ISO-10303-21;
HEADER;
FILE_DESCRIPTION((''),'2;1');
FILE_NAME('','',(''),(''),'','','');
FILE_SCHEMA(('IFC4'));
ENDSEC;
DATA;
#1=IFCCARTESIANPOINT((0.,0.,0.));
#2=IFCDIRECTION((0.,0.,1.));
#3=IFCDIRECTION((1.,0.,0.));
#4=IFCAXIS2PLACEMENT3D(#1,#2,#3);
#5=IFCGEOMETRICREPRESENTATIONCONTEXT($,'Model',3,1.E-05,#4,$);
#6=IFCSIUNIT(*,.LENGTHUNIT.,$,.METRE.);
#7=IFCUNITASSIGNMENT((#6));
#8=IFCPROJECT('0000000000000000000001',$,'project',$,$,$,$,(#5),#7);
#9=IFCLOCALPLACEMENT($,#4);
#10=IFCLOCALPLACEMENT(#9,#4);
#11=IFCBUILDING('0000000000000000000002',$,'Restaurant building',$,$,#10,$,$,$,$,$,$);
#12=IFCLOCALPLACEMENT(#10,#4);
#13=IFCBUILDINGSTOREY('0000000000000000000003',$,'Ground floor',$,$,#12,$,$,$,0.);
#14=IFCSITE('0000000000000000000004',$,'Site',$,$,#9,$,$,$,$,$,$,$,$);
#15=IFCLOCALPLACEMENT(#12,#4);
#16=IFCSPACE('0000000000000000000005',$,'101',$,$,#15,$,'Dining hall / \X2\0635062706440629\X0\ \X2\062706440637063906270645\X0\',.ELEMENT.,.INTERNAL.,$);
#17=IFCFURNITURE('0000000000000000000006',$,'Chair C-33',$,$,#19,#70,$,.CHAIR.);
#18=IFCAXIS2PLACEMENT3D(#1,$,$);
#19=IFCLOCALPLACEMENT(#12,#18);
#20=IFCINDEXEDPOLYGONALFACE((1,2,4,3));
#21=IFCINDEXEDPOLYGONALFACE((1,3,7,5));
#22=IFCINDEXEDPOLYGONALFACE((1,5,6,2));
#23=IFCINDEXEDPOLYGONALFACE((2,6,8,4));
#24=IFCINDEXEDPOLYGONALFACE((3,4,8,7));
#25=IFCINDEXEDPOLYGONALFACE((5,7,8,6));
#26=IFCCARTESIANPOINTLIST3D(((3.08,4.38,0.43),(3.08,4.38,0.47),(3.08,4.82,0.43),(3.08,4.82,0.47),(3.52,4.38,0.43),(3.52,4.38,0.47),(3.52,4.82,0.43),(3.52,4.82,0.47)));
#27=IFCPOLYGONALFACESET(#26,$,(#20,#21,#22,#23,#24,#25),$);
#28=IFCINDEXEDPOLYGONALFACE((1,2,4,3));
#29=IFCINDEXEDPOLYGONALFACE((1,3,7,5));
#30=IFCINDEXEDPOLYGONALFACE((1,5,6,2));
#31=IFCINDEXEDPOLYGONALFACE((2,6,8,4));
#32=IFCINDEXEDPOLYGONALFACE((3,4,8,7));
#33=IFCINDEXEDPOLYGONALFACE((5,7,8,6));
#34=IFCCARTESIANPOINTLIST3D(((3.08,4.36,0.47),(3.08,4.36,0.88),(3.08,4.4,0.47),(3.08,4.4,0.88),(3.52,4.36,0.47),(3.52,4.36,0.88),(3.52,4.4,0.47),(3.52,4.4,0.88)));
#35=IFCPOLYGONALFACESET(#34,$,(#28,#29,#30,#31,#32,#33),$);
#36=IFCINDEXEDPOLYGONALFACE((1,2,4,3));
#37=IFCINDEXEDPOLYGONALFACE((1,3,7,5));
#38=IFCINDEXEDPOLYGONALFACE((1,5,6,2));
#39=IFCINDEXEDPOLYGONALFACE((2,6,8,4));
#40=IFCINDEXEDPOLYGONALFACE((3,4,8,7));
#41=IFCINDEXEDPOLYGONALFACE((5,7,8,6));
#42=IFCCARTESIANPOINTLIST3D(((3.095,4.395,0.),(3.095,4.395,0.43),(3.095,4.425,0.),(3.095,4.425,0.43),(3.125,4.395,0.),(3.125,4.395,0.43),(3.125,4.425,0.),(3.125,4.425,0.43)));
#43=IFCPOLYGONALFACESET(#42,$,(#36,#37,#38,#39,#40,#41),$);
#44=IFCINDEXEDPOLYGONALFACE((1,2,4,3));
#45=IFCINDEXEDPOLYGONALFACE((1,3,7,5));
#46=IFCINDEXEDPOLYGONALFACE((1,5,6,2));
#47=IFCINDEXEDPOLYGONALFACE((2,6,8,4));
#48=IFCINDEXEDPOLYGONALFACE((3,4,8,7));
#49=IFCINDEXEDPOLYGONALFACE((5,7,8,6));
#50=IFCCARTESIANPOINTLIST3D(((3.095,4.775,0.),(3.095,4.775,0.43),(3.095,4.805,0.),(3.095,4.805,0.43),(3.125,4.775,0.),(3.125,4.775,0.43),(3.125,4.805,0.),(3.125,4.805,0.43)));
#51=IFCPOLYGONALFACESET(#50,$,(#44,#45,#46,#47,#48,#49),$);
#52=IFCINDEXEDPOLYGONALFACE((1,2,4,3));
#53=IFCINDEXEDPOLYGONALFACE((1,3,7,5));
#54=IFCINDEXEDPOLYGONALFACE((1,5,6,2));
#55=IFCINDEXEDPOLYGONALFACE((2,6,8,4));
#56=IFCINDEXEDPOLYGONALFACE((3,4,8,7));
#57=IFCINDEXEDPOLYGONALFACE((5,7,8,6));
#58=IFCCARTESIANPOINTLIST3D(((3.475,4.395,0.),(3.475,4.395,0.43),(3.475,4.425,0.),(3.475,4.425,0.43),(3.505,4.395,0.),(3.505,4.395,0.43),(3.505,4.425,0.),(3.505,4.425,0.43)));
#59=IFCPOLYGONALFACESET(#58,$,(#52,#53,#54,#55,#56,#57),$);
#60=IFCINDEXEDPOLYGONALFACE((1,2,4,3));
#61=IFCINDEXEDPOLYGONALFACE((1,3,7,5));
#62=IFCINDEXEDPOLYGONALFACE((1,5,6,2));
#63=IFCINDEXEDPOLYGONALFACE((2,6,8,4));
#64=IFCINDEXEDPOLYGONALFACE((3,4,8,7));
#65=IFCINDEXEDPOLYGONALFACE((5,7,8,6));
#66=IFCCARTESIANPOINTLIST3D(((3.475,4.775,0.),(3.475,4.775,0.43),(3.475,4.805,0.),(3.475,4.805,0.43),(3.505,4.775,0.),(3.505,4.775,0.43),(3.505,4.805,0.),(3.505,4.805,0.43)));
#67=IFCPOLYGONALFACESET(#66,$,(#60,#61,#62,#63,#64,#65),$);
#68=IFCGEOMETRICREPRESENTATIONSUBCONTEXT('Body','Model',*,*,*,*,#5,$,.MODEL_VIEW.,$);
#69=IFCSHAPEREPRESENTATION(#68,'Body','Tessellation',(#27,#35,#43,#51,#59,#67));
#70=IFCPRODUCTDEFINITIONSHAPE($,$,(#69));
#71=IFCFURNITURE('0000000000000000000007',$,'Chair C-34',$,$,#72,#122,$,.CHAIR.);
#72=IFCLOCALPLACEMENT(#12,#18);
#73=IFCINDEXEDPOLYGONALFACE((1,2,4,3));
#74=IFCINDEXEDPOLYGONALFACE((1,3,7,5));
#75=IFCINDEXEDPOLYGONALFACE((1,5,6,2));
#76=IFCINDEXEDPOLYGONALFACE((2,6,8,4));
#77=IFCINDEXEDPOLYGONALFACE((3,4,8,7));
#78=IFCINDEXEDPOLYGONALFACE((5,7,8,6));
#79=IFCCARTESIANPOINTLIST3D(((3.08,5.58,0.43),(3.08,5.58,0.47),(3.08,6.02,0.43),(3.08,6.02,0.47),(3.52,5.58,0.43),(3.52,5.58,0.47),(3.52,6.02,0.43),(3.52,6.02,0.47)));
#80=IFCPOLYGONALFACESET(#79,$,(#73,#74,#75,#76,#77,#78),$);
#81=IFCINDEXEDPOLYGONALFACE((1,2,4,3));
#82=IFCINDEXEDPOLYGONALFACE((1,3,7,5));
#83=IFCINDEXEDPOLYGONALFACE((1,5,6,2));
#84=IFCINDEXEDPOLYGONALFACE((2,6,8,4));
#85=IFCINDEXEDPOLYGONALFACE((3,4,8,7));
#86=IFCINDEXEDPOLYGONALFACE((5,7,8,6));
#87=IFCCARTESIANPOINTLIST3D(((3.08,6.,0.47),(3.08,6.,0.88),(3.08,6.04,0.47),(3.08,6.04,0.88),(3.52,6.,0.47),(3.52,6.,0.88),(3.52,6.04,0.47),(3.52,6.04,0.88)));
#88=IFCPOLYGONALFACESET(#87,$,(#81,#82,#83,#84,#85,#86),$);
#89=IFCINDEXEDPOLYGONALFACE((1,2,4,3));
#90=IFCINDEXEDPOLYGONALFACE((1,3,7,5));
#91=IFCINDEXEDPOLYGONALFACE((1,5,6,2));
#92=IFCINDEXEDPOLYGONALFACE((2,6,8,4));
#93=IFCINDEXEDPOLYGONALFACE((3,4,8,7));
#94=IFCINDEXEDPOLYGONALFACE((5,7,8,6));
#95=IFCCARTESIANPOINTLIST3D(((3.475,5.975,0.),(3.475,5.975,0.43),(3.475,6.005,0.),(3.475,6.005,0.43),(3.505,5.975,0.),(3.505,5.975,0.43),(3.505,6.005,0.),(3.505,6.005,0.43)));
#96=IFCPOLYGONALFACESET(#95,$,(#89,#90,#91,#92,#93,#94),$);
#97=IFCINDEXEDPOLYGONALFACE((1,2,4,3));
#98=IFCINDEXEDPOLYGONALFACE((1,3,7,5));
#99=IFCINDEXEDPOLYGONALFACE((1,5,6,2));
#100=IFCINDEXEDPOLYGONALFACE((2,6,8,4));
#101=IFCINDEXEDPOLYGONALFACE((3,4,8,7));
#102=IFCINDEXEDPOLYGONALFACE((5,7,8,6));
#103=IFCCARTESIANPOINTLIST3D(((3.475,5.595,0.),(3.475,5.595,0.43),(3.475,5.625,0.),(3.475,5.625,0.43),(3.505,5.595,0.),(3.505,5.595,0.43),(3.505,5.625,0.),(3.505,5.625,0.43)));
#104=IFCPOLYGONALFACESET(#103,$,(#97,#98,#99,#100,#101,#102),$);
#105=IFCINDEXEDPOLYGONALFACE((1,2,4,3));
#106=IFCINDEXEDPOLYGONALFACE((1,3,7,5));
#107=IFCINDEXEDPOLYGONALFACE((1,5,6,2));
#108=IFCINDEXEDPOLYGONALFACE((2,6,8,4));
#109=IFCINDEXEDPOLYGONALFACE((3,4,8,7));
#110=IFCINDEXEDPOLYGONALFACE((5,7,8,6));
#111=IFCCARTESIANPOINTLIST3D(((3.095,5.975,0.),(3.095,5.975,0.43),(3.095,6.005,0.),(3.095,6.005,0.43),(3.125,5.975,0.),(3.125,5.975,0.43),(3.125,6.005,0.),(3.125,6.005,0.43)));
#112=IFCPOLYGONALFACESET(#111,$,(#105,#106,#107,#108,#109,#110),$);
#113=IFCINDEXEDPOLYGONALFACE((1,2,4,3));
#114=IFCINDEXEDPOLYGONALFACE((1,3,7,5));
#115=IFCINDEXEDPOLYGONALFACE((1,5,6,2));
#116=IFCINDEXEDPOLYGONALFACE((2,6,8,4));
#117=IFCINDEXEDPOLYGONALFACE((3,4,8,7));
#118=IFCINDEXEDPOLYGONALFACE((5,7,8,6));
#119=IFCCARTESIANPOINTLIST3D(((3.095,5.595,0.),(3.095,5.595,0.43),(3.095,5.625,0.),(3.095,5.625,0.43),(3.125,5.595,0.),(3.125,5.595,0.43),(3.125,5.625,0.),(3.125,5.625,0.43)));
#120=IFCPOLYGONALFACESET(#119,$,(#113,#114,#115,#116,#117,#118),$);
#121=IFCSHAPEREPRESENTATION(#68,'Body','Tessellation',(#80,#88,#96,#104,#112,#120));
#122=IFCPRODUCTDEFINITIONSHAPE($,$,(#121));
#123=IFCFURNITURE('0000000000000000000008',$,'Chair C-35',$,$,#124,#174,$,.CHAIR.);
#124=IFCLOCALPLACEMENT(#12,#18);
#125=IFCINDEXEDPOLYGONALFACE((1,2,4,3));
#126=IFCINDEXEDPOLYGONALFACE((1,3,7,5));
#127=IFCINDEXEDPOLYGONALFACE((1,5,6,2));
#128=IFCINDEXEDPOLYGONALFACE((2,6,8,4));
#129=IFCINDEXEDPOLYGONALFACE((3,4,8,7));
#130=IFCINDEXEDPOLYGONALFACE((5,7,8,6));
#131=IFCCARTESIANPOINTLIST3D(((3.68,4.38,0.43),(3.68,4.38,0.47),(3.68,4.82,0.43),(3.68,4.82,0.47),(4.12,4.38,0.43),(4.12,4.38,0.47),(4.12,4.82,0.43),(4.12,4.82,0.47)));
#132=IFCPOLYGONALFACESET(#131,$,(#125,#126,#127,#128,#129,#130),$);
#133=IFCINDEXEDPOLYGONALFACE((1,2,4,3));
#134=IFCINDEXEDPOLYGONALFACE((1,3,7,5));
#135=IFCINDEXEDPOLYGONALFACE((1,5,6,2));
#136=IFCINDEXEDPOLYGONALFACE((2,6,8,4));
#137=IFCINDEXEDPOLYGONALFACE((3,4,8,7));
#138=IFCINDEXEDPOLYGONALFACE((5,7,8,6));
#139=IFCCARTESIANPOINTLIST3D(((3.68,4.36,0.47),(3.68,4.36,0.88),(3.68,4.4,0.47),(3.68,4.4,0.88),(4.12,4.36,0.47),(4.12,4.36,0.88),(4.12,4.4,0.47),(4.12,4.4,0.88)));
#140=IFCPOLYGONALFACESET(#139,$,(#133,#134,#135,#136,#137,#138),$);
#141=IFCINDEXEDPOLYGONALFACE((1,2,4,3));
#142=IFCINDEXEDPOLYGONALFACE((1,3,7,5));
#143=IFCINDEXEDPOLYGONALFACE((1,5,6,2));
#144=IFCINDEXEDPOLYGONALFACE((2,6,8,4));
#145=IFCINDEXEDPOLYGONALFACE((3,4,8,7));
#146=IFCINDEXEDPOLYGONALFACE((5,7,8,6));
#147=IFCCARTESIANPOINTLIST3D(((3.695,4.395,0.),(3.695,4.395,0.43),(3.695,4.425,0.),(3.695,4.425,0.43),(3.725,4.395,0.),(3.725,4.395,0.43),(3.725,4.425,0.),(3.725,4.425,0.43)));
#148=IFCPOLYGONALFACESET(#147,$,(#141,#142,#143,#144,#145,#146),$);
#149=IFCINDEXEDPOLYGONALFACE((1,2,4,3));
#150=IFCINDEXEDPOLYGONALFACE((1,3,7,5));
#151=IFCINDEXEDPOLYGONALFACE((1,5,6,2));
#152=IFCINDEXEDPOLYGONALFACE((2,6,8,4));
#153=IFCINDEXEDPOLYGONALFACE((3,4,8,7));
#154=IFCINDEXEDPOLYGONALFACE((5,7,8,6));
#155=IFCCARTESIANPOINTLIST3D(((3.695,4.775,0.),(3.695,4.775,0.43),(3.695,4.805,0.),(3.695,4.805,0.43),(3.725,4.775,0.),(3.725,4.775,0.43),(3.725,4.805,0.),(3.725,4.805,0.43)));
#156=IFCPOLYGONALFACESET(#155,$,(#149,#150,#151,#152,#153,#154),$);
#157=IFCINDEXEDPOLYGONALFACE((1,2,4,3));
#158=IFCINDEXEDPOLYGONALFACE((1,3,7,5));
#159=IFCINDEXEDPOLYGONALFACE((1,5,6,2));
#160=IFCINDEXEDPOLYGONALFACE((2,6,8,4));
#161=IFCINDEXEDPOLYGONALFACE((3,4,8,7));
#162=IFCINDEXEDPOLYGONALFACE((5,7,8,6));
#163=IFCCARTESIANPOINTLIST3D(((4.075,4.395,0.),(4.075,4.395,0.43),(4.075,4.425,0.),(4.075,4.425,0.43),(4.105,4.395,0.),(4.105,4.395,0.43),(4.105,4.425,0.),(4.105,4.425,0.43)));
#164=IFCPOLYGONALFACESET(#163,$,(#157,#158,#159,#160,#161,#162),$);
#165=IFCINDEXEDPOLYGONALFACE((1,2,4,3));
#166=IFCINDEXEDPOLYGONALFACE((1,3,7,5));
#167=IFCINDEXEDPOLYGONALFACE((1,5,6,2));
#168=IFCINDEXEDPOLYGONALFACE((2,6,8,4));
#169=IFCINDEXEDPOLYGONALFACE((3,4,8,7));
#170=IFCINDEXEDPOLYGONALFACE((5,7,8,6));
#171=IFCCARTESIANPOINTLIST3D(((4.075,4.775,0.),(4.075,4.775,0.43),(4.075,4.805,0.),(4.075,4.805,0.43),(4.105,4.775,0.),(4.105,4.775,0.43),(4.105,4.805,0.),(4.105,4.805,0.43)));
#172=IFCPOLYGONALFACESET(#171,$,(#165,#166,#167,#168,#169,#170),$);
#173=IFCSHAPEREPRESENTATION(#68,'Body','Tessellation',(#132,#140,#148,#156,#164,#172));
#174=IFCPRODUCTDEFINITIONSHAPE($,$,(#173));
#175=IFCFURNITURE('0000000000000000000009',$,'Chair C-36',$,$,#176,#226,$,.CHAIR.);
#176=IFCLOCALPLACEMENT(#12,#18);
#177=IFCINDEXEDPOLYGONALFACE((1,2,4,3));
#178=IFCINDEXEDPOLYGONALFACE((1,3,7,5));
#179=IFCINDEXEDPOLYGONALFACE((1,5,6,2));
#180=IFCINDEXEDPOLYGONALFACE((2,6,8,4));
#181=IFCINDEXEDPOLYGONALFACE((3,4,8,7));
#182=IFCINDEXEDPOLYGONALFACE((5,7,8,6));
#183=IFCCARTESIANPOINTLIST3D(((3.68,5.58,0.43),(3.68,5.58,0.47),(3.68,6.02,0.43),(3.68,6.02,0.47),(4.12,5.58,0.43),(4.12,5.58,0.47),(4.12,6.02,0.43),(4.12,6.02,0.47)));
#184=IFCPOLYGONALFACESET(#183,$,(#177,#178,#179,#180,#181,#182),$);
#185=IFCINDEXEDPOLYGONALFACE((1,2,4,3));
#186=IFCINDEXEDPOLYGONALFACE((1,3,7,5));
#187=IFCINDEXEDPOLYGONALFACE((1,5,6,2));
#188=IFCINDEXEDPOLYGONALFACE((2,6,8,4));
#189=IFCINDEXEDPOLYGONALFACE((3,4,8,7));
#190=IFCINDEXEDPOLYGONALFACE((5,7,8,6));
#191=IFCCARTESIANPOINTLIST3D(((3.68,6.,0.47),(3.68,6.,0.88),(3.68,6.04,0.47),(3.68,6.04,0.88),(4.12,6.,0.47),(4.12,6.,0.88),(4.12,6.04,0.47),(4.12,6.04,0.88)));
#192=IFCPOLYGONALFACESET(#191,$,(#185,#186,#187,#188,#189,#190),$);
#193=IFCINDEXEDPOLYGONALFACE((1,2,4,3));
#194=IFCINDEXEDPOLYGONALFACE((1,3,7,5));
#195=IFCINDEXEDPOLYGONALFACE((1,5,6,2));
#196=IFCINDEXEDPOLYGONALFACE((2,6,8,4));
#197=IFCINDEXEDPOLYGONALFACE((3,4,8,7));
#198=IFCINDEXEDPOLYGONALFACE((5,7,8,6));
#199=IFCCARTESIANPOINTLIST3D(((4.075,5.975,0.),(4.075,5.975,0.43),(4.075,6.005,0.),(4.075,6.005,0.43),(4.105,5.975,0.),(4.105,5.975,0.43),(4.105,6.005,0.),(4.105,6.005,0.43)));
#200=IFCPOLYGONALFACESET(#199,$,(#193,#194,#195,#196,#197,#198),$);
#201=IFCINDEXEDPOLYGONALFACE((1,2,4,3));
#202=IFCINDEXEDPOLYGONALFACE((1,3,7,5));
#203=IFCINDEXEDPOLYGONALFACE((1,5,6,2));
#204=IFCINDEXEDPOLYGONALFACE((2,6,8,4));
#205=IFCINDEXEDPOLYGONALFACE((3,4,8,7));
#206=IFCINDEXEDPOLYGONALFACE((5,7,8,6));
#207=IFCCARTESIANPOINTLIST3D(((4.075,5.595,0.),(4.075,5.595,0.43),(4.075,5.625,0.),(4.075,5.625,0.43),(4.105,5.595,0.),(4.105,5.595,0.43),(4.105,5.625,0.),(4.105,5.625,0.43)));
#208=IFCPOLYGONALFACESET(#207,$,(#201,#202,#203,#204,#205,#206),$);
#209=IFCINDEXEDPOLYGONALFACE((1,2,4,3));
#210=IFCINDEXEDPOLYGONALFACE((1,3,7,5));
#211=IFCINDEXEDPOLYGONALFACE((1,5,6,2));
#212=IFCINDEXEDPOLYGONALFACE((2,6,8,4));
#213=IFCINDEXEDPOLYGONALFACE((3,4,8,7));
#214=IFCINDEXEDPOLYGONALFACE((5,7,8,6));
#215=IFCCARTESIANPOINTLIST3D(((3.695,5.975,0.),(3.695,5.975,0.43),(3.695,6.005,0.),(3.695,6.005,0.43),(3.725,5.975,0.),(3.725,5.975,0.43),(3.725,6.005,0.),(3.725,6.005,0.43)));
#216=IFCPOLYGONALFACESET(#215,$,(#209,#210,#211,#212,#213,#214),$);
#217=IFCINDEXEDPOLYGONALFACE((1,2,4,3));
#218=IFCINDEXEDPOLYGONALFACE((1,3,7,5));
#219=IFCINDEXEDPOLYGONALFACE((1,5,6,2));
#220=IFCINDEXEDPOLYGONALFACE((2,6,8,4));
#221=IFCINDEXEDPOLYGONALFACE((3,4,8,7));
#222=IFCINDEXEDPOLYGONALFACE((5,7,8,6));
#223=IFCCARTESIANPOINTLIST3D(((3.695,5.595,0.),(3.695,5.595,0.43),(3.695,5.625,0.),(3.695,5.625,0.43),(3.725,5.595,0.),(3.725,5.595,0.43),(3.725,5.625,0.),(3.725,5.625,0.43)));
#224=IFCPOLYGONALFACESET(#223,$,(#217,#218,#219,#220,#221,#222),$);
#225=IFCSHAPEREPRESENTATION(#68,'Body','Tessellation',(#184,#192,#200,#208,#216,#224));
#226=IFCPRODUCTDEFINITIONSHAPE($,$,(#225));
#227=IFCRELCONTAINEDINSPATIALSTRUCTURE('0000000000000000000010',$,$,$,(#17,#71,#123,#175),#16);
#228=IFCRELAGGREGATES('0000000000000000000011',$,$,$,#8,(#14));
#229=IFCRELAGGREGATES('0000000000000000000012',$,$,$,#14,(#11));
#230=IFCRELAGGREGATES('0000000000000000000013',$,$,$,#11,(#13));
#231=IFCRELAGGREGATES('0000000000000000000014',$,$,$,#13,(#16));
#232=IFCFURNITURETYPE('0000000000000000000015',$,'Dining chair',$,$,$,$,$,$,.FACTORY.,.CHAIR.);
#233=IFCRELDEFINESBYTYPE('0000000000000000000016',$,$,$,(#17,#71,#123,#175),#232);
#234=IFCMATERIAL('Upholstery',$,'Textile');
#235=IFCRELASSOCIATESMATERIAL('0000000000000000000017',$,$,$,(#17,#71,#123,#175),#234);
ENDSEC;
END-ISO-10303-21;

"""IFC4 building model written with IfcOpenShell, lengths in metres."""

from ifc_helpers import new_model, si_unit, frame, origin, origin_with_axes, origin_2d, place, context, subcontext, project, spatial, rectangle, extrude, source, transform, mapped, material, type_object, type_shapes, element, save


model = new_model("IFC4")

# Units and contexts
model_context = context("Model", 3, precision=1e-05, world=origin_with_axes())
body_context = subcontext(model_context, "Body", "Model", "MODEL_VIEW")
ifc_project = project(units=[si_unit("LENGTHUNIT", "METRE")], contexts=[model_context])

# Site, building, storey, space
site_placement = place(None, origin_with_axes())
site = spatial("IfcSite", under=ifc_project, at=site_placement, Name="Site")
building_placement = place(site_placement, origin_with_axes())
building = spatial("IfcBuilding", under=site, at=building_placement, Name="Restaurant building")
storey_placement = place(building_placement, origin_with_axes())
storey = spatial("IfcBuildingStorey", under=building, at=storey_placement, Name="Ground floor", Elevation=0.0)
space_placement = place(storey_placement, origin_with_axes())
space = spatial("IfcSpace", under=storey, at=space_placement, Name="101", LongName="Dining hall / صالة الطعام", CompositionType="ELEMENT", PredefinedType="INTERNAL")

# Furniture
ifc_material_1 = material(Name="Upholstery", Category="Textile")
furniture_type_1 = type_object("IfcFurnitureType", Name="Dining chair", AssemblyPlace="FACTORY", PredefinedType="CHAIR")
shared_shape_1 = source(origin(), body_context, "Body", "SweptSolid", [
    extrude(rectangle(XDim=0.44, YDim=0.44, at=origin_2d()), frame((0.0, 0.0, 0.43)), (0.0, 0.0, 1.0), 0.04),
    extrude(rectangle(XDim=0.44, YDim=0.04, at=origin_2d()), frame((0.0, -0.22, 0.47)), (0.0, 0.0, 1.0), 0.41),
    extrude(rectangle(XDim=0.03, YDim=0.03, at=origin_2d()), frame((-0.19, -0.19, 0.0)), (0.0, 0.0, 1.0), 0.43),
    extrude(rectangle(XDim=0.03, YDim=0.03, at=origin_2d()), frame((-0.19, 0.19, 0.0)), (0.0, 0.0, 1.0), 0.43),
    extrude(rectangle(XDim=0.03, YDim=0.03, at=origin_2d()), frame((0.19, -0.19, 0.0)), (0.0, 0.0, 1.0), 0.43),
    extrude(rectangle(XDim=0.03, YDim=0.03, at=origin_2d()), frame((0.19, 0.19, 0.0)), (0.0, 0.0, 1.0), 0.43),
])
type_shapes(furniture_type_1, [shared_shape_1])
furniture_1_placement = place(storey_placement, frame((3.3, 4.6, 0.0)))
element("IfcFurniture", 1, at=furniture_1_placement, inside=space, type_object=furniture_type_1, material=ifc_material_1, Name="Chair C-33", PredefinedType="CHAIR", context=body_context, shape_type="MappedRepresentation", body=[
    mapped(shared_shape_1, transform((0.0, 0.0, 0.0))),
])
furniture_2_placement = place(storey_placement, frame((3.3, 5.8, 0.0), z_axis=(0.0, 0.0, 1.0), x_axis=(-1.0, 0.0, 0.0)))
element("IfcFurniture", 2, at=furniture_2_placement, inside=space, type_object=furniture_type_1, material=ifc_material_1, Name="Chair C-34", PredefinedType="CHAIR", context=body_context, shape_type="MappedRepresentation", body=[
    mapped(shared_shape_1, transform((0.0, 0.0, 0.0))),
])
furniture_3_placement = place(storey_placement, frame((3.9, 4.6, 0.0)))
element("IfcFurniture", 3, at=furniture_3_placement, inside=space, type_object=furniture_type_1, material=ifc_material_1, Name="Chair C-35", PredefinedType="CHAIR", context=body_context, shape_type="MappedRepresentation", body=[
    mapped(shared_shape_1, transform((0.0, 0.0, 0.0))),
])
furniture_4_placement = place(storey_placement, frame((3.9, 5.8, 0.0), z_axis=(0.0, 0.0, 1.0), x_axis=(-1.0, 0.0, 0.0)))
element("IfcFurniture", 4, at=furniture_4_placement, inside=space, type_object=furniture_type_1, material=ifc_material_1, Name="Chair C-36", PredefinedType="CHAIR", context=body_context, shape_type="MappedRepresentation", body=[
    mapped(shared_shape_1, transform((0.0, 0.0, 0.0))),
])

save(model, "model.ifc")
